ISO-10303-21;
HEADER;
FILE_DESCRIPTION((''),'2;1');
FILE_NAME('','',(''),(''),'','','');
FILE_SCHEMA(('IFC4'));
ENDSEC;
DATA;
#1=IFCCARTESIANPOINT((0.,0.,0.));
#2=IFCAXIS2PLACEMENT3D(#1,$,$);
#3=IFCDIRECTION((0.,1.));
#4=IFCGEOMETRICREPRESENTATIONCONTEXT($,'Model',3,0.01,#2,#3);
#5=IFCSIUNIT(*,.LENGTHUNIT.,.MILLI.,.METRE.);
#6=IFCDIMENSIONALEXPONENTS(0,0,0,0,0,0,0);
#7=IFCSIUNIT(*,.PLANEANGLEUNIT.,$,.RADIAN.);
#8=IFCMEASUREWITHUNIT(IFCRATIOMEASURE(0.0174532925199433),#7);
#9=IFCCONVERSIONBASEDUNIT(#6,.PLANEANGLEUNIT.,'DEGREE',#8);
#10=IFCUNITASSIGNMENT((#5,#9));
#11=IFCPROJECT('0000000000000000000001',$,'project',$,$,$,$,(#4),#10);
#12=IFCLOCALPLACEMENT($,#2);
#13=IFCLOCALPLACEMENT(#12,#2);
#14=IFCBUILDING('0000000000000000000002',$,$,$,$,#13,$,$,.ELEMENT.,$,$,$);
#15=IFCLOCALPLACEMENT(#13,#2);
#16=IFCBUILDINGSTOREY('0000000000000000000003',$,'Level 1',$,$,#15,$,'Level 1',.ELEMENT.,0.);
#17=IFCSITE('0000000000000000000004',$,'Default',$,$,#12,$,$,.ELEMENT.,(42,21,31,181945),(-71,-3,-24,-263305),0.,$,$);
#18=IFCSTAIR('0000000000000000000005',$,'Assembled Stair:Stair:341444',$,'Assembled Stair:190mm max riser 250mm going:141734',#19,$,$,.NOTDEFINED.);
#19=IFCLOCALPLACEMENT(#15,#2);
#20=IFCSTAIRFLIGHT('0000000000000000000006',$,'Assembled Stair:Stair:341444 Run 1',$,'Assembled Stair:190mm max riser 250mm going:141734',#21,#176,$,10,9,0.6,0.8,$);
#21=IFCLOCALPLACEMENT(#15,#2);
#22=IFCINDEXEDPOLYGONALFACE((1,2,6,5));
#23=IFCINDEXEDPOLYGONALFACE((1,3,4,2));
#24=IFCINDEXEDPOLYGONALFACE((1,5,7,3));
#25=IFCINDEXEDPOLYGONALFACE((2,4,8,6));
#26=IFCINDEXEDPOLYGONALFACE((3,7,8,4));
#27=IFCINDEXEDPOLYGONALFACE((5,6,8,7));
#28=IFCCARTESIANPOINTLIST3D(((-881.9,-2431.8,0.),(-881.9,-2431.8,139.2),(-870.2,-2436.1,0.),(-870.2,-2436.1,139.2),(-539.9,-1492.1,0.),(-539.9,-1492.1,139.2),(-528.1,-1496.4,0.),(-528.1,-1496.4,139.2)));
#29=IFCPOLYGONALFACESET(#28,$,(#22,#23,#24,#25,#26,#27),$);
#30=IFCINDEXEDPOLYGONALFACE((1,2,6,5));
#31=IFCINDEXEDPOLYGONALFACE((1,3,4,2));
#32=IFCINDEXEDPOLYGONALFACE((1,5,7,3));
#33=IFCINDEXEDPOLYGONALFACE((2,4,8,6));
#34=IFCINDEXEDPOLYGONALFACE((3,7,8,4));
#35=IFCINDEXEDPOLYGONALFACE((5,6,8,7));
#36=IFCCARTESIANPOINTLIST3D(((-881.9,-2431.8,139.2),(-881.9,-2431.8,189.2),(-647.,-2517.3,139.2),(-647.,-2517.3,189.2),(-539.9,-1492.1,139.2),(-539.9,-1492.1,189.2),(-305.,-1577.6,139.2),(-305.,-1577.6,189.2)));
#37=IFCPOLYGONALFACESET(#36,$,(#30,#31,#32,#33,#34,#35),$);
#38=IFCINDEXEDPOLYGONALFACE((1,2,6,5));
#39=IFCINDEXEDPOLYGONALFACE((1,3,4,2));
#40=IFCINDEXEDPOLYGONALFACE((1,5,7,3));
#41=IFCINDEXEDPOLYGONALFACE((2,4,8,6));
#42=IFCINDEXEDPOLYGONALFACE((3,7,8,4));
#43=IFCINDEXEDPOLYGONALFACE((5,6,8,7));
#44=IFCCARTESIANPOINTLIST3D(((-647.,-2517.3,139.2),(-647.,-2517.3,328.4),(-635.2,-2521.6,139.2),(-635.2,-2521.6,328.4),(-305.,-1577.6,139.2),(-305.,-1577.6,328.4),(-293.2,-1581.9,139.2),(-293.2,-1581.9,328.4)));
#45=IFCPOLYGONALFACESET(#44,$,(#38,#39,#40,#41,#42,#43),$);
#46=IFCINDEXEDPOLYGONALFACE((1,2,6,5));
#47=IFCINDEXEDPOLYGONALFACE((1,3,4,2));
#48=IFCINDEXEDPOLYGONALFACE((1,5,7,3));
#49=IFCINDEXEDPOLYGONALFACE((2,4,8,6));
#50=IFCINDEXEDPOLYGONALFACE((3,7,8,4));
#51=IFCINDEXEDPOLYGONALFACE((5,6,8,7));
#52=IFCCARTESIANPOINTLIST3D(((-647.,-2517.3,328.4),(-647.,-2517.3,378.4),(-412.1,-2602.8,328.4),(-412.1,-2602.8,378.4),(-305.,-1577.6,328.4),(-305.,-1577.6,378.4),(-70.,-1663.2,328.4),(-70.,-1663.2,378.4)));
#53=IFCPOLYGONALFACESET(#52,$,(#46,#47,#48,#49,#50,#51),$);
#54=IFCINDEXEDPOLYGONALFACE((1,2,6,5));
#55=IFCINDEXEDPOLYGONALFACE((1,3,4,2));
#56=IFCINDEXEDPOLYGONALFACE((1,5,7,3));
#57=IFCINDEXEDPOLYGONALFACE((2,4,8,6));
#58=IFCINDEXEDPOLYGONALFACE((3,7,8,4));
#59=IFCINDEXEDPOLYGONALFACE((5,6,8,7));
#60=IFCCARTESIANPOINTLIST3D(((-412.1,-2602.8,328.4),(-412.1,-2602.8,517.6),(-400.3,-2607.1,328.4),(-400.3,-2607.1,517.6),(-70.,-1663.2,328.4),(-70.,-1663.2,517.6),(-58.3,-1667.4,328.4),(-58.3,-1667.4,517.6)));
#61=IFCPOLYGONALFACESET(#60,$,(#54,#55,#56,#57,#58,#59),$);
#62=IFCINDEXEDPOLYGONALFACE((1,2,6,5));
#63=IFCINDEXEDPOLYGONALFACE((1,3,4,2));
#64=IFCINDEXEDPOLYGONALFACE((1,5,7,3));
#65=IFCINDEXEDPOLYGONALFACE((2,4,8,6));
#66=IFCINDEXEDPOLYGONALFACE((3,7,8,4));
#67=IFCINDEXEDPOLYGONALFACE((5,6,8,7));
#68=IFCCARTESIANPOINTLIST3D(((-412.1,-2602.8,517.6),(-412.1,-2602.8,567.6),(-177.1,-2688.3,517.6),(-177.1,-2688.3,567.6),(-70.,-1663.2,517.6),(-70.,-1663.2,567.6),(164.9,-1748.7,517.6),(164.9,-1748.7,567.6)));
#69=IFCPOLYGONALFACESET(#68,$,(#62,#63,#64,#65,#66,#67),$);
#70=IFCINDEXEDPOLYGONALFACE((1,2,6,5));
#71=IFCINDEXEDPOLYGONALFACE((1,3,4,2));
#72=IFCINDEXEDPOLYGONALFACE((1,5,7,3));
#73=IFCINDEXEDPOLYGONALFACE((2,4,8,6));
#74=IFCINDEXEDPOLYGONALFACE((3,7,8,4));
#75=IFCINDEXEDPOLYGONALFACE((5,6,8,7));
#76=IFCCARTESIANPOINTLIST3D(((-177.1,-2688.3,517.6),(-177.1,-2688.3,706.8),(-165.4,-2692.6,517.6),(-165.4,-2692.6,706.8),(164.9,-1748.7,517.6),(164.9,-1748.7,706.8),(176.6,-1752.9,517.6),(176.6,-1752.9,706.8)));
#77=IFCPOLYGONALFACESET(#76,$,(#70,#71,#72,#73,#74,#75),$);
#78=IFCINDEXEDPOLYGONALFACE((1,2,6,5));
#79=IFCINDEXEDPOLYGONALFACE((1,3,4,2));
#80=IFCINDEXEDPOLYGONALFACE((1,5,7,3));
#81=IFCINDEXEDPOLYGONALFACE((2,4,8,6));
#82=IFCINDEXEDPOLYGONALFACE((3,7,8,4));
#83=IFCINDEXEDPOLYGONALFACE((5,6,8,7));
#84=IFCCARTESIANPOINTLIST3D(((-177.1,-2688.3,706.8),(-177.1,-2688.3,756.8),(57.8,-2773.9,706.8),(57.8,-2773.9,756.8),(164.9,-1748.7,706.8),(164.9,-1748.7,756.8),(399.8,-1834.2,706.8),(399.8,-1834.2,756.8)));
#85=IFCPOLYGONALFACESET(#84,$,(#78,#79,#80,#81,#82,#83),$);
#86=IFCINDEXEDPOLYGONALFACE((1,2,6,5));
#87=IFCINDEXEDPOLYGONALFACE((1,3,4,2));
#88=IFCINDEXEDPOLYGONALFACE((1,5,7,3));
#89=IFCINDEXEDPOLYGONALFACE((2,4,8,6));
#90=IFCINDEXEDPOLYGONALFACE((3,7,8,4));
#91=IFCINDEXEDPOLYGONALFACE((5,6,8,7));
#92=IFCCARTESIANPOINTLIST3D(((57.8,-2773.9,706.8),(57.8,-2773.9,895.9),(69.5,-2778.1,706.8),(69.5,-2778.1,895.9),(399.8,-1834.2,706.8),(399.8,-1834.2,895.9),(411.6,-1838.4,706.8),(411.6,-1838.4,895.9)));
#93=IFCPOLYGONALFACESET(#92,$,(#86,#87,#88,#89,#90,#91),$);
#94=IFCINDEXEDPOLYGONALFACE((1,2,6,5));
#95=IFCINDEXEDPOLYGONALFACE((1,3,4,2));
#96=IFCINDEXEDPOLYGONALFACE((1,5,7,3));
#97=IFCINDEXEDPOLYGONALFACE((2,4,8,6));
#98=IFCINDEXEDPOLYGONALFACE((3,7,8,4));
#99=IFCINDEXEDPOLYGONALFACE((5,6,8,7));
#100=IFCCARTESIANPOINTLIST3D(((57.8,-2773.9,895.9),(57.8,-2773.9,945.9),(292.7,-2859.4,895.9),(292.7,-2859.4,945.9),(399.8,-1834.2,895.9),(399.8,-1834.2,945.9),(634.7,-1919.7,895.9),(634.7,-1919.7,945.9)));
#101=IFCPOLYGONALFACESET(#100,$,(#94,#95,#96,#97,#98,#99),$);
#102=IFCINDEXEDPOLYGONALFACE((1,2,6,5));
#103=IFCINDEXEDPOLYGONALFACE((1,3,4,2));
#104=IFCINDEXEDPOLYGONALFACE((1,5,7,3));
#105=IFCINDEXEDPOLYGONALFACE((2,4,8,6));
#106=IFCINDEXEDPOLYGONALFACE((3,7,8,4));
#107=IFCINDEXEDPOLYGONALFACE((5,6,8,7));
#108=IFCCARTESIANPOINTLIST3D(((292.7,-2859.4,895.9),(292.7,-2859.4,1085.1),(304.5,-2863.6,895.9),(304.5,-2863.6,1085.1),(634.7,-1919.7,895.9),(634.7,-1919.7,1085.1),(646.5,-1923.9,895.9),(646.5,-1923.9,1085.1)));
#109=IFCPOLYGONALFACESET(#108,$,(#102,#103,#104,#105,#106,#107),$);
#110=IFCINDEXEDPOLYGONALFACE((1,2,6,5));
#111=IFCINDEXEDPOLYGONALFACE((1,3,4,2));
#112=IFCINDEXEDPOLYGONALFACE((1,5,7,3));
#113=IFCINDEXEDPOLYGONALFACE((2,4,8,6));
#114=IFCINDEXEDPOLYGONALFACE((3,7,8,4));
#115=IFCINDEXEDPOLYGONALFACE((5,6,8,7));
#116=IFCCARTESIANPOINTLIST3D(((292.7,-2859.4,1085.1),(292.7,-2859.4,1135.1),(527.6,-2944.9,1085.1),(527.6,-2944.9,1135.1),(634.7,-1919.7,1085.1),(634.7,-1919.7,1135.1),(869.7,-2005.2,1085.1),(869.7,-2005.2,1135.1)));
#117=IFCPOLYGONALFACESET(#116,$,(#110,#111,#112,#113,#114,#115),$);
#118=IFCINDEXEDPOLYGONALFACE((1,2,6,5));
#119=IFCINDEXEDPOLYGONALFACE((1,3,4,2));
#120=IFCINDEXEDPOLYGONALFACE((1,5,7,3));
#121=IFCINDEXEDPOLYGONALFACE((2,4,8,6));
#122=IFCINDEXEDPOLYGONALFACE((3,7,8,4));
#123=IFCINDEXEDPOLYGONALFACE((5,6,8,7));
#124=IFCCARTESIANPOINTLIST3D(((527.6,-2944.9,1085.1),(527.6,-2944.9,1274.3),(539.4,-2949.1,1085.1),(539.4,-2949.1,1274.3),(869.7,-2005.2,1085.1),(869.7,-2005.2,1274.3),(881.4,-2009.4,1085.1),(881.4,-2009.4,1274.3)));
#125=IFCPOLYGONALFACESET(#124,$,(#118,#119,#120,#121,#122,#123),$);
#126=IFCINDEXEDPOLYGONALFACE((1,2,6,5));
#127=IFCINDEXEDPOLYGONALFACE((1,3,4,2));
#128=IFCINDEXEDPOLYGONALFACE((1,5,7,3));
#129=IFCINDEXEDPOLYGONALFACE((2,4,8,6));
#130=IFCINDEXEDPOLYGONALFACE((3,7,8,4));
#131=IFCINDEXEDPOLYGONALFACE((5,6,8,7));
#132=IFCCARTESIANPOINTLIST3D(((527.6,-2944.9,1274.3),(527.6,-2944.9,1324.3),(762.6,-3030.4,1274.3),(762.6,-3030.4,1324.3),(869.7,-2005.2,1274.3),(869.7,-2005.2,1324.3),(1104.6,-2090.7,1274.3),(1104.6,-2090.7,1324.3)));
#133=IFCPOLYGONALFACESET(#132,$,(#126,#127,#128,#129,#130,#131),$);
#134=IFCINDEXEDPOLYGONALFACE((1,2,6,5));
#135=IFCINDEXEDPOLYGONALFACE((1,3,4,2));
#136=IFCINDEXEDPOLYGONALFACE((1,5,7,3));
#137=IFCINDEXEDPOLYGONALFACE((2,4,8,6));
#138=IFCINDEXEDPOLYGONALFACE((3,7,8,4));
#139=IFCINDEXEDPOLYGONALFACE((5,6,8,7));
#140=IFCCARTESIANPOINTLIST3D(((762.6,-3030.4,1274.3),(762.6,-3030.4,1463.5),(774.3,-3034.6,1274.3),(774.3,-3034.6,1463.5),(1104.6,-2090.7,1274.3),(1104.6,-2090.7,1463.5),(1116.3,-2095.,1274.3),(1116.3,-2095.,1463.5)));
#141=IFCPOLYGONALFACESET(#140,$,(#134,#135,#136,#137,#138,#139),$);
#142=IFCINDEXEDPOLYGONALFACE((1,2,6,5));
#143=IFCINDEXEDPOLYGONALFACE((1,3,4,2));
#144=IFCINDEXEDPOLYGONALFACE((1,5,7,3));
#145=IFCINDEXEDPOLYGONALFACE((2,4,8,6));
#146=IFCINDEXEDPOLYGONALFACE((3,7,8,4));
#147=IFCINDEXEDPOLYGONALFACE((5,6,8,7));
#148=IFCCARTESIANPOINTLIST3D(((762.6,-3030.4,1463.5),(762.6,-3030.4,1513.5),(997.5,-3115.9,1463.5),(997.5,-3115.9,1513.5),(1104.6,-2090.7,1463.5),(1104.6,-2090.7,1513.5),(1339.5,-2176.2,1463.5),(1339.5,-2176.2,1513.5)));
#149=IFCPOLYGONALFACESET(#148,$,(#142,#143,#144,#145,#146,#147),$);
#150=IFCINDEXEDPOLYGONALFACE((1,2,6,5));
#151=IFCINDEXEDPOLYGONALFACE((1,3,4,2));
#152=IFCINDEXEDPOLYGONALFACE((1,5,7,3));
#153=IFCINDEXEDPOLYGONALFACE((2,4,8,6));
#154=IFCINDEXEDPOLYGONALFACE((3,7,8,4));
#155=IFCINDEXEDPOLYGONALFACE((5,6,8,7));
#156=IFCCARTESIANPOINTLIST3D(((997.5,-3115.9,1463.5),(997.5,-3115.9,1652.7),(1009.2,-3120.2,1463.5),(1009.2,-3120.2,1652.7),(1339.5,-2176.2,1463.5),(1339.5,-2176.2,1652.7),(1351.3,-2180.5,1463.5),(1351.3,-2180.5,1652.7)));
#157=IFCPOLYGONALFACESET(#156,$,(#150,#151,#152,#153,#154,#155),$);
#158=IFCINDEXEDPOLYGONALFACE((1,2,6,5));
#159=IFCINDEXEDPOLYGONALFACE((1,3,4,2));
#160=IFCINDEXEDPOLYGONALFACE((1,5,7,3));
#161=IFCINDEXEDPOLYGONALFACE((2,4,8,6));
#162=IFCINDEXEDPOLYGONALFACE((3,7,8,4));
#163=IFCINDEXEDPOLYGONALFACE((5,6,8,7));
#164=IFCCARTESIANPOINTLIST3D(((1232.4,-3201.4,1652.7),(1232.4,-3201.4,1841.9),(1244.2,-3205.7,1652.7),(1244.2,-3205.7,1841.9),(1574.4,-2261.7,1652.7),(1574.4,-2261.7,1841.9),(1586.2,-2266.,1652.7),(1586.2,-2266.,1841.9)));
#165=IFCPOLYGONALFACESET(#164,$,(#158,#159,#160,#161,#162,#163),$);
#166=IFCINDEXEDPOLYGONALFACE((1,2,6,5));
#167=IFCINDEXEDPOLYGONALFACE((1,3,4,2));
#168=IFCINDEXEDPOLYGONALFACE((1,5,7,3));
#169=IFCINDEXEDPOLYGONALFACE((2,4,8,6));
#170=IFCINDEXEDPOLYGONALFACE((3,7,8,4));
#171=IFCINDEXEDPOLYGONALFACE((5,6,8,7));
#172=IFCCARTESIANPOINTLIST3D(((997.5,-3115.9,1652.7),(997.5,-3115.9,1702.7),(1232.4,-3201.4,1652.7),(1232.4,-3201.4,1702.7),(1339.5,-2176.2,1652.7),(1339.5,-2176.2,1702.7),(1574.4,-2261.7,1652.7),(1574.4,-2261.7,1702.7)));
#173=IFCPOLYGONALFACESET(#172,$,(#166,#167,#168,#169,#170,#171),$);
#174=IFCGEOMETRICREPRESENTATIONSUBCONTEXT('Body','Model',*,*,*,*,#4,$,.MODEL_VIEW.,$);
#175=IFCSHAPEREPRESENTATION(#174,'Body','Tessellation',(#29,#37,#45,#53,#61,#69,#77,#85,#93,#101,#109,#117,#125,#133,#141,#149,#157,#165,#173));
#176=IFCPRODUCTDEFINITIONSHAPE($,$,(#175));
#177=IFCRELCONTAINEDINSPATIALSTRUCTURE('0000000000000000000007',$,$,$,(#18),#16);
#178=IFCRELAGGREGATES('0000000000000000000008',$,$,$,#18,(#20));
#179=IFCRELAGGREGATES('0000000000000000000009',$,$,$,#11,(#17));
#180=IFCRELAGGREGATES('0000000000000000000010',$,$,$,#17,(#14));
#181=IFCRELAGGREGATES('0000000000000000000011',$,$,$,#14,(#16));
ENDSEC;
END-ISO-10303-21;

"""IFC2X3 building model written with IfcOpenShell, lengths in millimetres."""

from ifc_helpers import new_model, entity, si_unit, converted_unit, direction, frame, frame_2d, origin, origin_2d_with_axis, place, context, subcontext, project, spatial, rectangle, extrude, element, aggregate, save


model = new_model("IFC2X3")

# Units and contexts
model_context = context("Model", 3, precision=0.01, world=origin(), true_north=direction((0.0, 1.0)))
body_context = subcontext(model_context, "Body", "Model", "MODEL_VIEW")
ifc_project = project(units=[si_unit("LENGTHUNIT", "METRE", prefix="MILLI"), converted_unit("PLANEANGLEUNIT", "DEGREE", entity("IfcRatioMeasure", 0.0174532925199433), si_unit("PLANEANGLEUNIT", "RADIAN"), dimensions=[0, 0, 0, 0, 0, 0, 0])], contexts=[model_context])

# Site, building, storey
site_placement = place(None, origin())
site = spatial("IfcSite", under=ifc_project, at=site_placement, Name="Default", CompositionType="ELEMENT", RefLatitude=(42, 21, 31, 181945), RefLongitude=(-71, -3, -24, -263305), RefElevation=0.0)
building_placement = place(site_placement, origin())
building = spatial("IfcBuilding", under=site, at=building_placement, CompositionType="ELEMENT")
storey_placement = place(building_placement, origin())
storey = spatial("IfcBuildingStorey", under=building, at=storey_placement, Name="Level 1", LongName="Level 1", CompositionType="ELEMENT", Elevation=0.0)

# Stair
stair_placement = place(storey_placement, origin())
stair = element("IfcStair", 1, at=stair_placement, inside=storey, Name="Assembled Stair:Stair:341444", ObjectType="Assembled Stair:190mm max riser 250mm going:141734", ShapeType="NOTDEFINED")

# Stair flight
stair_flight_1_placement = place(stair_placement, origin())
stair_flight_1 = element("IfcStairFlight", 2, at=stair_flight_1_placement, Name="Assembled Stair:Stair:341444 Run 1", ObjectType="Assembled Stair:190mm max riser 250mm going:141734", NumberOfRiser=10, NumberOfTreads=9, RiserHeight=0.6, TreadLength=0.8, context=body_context, shape_type="SweptSolid", body=[
    extrude(rectangle(XDim=1000.0, YDim=12.5, at=frame_2d((0.0, 0.0), x_axis=(1.0, 0.0))), frame((-705.0, -1964.1, 0.0), z_axis=(0.0, 0.0, 1.0), x_axis=(0.34202, 0.939693, 0.0)), (0.0, 0.0, 1.0), 139.2),
    extrude(rectangle(XDim=250.0, YDim=1000.0, at=frame_2d((0.0, 0.0), x_axis=(1.0, 0.0))), frame((-593.4, -2004.7, 139.2), z_axis=(0.0, 0.0, 1.0), x_axis=(-0.939693, 0.34202, 0.0)), (0.0, 0.0, 1.0), 50.0),
    extrude(rectangle(XDim=1000.0, YDim=12.5, at=frame_2d((0.0, 0.0), x_axis=(1.0, 0.0))), frame((-470.1, -2049.6, 139.2), z_axis=(0.0, 0.0, 1.0), x_axis=(0.34202, 0.939693, 0.0)), (0.0, 0.0, 1.0), 189.2),
    extrude(rectangle(XDim=250.0, YDim=1000.0, at=origin_2d_with_axis()), frame((-358.5, -2090.2, 328.4), z_axis=(0.0, 0.0, 1.0), x_axis=(-0.939693, 0.34202, 0.0)), (0.0, 0.0, 1.0), 50.0),
    extrude(rectangle(XDim=1000.0, YDim=12.5, at=origin_2d_with_axis()), frame((-235.2, -2135.1, 328.4), z_axis=(0.0, 0.0, 1.0), x_axis=(0.34202, 0.939693, 0.0)), (0.0, 0.0, 1.0), 189.2),
    extrude(rectangle(XDim=250.0, YDim=1000.0, at=frame_2d((0.0, 0.0), x_axis=(1.0, 0.0))), frame((-123.6, -2175.8, 517.6), z_axis=(0.0, 0.0, 1.0), x_axis=(-0.939693, 0.34202, 0.0)), (0.0, 0.0, 1.0), 50.0),
    extrude(rectangle(XDim=1000.0, YDim=12.5, at=frame_2d((0.0, 0.0), x_axis=(1.0, 0.0))), frame((-0.2, -2220.6, 517.6), z_axis=(0.0, 0.0, 1.0), x_axis=(0.34202, 0.939693, 0.0)), (0.0, 0.0, 1.0), 189.2),
    extrude(rectangle(XDim=250.0, YDim=1000.0, at=frame_2d((0.0, 0.0), x_axis=(1.0, 0.0))), frame((111.3, -2261.3, 706.8), z_axis=(0.0, 0.0, 1.0), x_axis=(-0.939693, 0.34202, 0.0)), (0.0, 0.0, 1.0), 50.0),
    extrude(rectangle(XDim=1000.0, YDim=12.5, at=frame_2d((0.0, 0.0), x_axis=(1.0, 0.0))), frame((234.7, -2306.1, 706.8), z_axis=(0.0, 0.0, 1.0), x_axis=(0.34202, 0.939693, 0.0)), (0.0, 0.0, 1.0), 189.2),
    extrude(rectangle(XDim=250.0, YDim=1000.0, at=frame_2d((0.0, 0.0), x_axis=(1.0, 0.0))), frame((346.3, -2346.8, 895.9), z_axis=(0.0, 0.0, 1.0), x_axis=(-0.939693, 0.34202, 0.0)), (0.0, 0.0, 1.0), 50.0),
    extrude(rectangle(XDim=1000.0, YDim=12.5, at=frame_2d((0.0, 0.0), x_axis=(1.0, 0.0))), frame((469.6, -2391.7, 895.9), z_axis=(0.0, 0.0, 1.0), x_axis=(0.34202, 0.939693, 0.0)), (0.0, 0.0, 1.0), 189.2),
    extrude(rectangle(XDim=250.0, YDim=1000.0, at=frame_2d((0.0, 0.0), x_axis=(1.0, 0.0))), frame((581.2, -2432.3, 1085.1), z_axis=(0.0, 0.0, 1.0), x_axis=(-0.939693, 0.34202, 0.0)), (0.0, 0.0, 1.0), 50.0),
    extrude(rectangle(XDim=1000.0, YDim=12.5, at=frame_2d((0.0, 0.0), x_axis=(1.0, 0.0))), frame((704.5, -2477.2, 1085.1), z_axis=(0.0, 0.0, 1.0), x_axis=(0.34202, 0.939693, 0.0)), (0.0, 0.0, 1.0), 189.2),
    extrude(rectangle(XDim=250.0, YDim=1000.0, at=origin_2d_with_axis()), frame((816.1, -2517.8, 1274.3), z_axis=(0.0, 0.0, 1.0), x_axis=(-0.939693, 0.34202, 0.0)), (0.0, 0.0, 1.0), 50.0),
    extrude(rectangle(XDim=1000.0, YDim=12.5, at=frame_2d((0.0, 0.0), x_axis=(1.0, 0.0))), frame((939.4, -2562.7, 1274.3), z_axis=(0.0, 0.0, 1.0), x_axis=(0.34202, 0.939693, 0.0)), (0.0, 0.0, 1.0), 189.2),
    extrude(rectangle(XDim=250.0, YDim=1000.0, at=frame_2d((0.0, 0.0), x_axis=(1.0, 0.0))), frame((1051.0, -2603.3, 1463.5), z_axis=(0.0, 0.0, 1.0), x_axis=(-0.939693, 0.34202, 0.0)), (0.0, 0.0, 1.0), 50.0),
    extrude(rectangle(XDim=1000.0, YDim=12.5, at=frame_2d((0.0, 0.0), x_axis=(1.0, 0.0))), frame((1174.4, -2648.2, 1463.5), z_axis=(0.0, 0.0, 1.0), x_axis=(0.34202, 0.939693, 0.0)), (0.0, 0.0, 1.0), 189.2),
    extrude(rectangle(XDim=1000.0, YDim=12.5, at=origin_2d_with_axis()), frame((1409.3, -2733.7, 1652.7), z_axis=(0.0, 0.0, 1.0), x_axis=(0.34202, 0.939693, 0.0)), (0.0, 0.0, 1.0), 189.2),
    extrude(rectangle(XDim=250.0, YDim=1000.0, at=origin_2d_with_axis()), frame((1286.0, -2688.8, 1652.7), z_axis=(0.0, 0.0, 1.0), x_axis=(-0.939693, 0.34202, 0.0)), (0.0, 0.0, 1.0), 50.0),
])
aggregate(stair, [stair_flight_1])

save(model, "model.ifc")
